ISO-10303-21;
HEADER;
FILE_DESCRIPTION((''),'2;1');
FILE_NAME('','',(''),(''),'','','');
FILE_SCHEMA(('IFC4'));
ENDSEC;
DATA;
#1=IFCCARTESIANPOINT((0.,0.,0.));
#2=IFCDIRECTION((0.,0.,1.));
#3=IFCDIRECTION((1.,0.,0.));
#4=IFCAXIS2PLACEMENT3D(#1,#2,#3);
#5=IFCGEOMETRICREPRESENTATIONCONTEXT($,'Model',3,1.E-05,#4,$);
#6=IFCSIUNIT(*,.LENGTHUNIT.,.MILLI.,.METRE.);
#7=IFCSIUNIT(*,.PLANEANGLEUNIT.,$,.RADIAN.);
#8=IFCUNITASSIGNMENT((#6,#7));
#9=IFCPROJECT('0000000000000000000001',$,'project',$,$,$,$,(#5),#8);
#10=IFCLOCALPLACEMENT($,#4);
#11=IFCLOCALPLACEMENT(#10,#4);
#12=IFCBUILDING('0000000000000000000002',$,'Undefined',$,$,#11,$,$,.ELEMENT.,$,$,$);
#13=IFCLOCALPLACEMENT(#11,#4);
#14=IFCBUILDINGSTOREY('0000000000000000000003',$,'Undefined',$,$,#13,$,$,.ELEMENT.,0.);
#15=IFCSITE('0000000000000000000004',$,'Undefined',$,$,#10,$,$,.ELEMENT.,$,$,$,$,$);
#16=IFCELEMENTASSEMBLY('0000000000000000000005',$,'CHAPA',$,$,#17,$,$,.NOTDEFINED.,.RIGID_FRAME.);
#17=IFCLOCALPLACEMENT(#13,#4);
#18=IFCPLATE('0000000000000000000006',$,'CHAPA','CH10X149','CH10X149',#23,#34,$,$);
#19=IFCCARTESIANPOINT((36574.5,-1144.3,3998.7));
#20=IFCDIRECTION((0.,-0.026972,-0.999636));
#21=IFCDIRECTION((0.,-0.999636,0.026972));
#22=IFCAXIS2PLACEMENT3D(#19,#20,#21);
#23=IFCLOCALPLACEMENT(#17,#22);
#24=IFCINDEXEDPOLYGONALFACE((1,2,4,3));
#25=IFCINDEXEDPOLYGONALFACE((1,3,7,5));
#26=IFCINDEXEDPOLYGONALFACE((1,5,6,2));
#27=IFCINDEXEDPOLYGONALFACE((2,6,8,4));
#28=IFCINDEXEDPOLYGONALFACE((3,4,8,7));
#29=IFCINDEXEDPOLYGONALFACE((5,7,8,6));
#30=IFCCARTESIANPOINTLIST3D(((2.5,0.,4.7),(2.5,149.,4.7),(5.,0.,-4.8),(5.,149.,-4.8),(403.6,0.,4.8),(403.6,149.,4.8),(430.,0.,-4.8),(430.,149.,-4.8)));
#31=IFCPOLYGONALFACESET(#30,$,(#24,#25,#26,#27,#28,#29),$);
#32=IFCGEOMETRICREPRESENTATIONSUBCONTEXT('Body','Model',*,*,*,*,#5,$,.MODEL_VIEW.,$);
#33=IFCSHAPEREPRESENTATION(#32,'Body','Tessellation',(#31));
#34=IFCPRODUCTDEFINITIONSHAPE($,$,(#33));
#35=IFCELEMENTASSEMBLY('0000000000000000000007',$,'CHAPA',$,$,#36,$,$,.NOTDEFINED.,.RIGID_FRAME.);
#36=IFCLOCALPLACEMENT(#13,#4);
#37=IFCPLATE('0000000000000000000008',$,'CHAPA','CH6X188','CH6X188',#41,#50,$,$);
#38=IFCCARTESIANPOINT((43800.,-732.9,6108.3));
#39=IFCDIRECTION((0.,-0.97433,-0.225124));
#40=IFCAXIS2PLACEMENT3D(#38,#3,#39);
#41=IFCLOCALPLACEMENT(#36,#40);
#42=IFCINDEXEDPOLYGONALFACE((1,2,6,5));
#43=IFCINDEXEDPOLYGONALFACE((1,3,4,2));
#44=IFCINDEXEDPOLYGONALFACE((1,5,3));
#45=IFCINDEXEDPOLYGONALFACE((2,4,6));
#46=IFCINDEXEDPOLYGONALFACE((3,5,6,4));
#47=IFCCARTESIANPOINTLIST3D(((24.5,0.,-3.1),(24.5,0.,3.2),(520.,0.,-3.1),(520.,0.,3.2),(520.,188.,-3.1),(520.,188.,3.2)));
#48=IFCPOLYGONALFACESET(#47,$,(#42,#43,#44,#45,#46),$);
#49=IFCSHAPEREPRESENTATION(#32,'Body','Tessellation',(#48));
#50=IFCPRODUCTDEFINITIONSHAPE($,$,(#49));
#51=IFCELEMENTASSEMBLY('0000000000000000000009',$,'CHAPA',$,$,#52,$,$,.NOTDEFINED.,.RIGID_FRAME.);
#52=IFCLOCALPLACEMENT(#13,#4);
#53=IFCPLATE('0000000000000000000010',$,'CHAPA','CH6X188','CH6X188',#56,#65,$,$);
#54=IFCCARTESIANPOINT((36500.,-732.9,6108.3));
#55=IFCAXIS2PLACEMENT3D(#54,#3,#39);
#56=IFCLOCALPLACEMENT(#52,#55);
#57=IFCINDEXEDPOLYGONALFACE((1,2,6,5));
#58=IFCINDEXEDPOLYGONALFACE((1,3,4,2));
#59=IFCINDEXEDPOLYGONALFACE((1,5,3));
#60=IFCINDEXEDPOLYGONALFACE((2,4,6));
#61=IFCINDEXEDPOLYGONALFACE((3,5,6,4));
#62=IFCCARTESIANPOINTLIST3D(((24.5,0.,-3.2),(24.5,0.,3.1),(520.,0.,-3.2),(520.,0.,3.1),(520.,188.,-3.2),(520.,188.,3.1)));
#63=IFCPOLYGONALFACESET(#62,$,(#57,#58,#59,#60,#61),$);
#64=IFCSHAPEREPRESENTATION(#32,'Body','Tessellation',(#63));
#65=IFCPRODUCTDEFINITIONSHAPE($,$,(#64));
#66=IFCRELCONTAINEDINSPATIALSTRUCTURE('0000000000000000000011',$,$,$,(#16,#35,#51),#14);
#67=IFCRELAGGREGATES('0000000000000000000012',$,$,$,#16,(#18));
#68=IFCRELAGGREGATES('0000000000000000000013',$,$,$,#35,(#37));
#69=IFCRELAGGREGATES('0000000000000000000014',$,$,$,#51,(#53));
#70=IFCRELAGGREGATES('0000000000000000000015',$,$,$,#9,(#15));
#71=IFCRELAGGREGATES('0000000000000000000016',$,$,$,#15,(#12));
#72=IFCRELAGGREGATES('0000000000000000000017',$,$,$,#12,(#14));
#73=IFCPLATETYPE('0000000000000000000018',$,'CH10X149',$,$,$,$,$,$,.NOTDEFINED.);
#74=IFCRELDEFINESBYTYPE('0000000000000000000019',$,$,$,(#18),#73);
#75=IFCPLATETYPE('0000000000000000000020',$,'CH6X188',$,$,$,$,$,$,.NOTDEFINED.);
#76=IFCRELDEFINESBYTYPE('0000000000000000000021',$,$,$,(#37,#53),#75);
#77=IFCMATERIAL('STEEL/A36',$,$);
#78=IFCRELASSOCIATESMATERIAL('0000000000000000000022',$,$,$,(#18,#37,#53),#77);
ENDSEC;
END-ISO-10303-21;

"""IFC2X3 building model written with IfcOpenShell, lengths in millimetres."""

from ifc_helpers import new_model, si_unit, frame, origin_with_axes, place, context, subcontext, project, spatial, polyline, outline, extrude, clip, halfspace, material, type_object, element, aggregate, save


model = new_model("IFC2X3")

# Units and contexts
model_context = context("Model", 3, precision=1e-05, world=origin_with_axes())
body_context = subcontext(model_context, "Body", "Model", "MODEL_VIEW")
ifc_project = project(units=[si_unit("LENGTHUNIT", "METRE", prefix="MILLI"), si_unit("PLANEANGLEUNIT", "RADIAN")], contexts=[model_context])

# Site, building, storey
site_placement = place(None, origin_with_axes())
site = spatial("IfcSite", under=ifc_project, at=site_placement, Name="Undefined", CompositionType="ELEMENT")
building_placement = place(site_placement, origin_with_axes())
building = spatial("IfcBuilding", under=site, at=building_placement, Name="Undefined", CompositionType="ELEMENT")
storey_placement = place(building_placement, origin_with_axes())
storey = spatial("IfcBuildingStorey", under=building, at=storey_placement, Name="Undefined", CompositionType="ELEMENT", Elevation=0.0)

# Shared definitions
ifc_material_1 = material(Name="STEEL/A36")

# Element assemblies, plates
plate_type_1 = type_object("IfcPlateType", Name="CH10X149", PredefinedType="NOTDEFINED")
assembly_1_placement = place(storey_placement, origin_with_axes())
assembly_1 = element("IfcElementAssembly", 1, at=assembly_1_placement, inside=storey, Name="CHAPA", AssemblyPlace="NOTDEFINED", PredefinedType="RIGID_FRAME")
plate_1_placement = place(assembly_1_placement, frame((36574.5, -1144.3, 3998.7), z_axis=(0.0, -0.026972, -0.999636), x_axis=(0.0, -0.999636, 0.026972)))
plate_1 = element("IfcPlate", 2, at=plate_1_placement, type_object=plate_type_1, material=ifc_material_1, Name="CHAPA", Description="CH10X149", ObjectType="CH10X149", context=body_context, shape_type="Clipping", body=[
    clip(clip(extrude(outline(polyline([(0.0, 0.0), (430.0, 0.0), (430.0, 149.0), (0.0, 149.0), (0.0, 0.0)])), frame((0.0, 0.0, -4.8), z_axis=(0.0, 0.0, 1.0), x_axis=(1.0, 0.0, 0.0)), (0.0, 0.0, 1.0), 9.5), halfspace(frame((403.6, -500.0, 4.7), z_axis=(0.33881, 0.0, 0.940855), x_axis=(0.0, 1.0, 0.0)), False)), halfspace(frame((5.0, -500.0, -4.8), z_axis=(-0.965989, 0.0, -0.258583), x_axis=(0.0, 1.0, 0.0)), False)),
])
aggregate(assembly_1, [plate_1])
assembly_2_placement = place(storey_placement, origin_with_axes())
assembly_2 = element("IfcElementAssembly", 3, at=assembly_2_placement, inside=storey, Name="CHAPA", AssemblyPlace="NOTDEFINED", PredefinedType="RIGID_FRAME")
plate_type_2 = type_object("IfcPlateType", Name="CH6X188", PredefinedType="NOTDEFINED")
plate_2_placement = place(assembly_2_placement, frame((43800.0, -732.9, 6108.3), z_axis=(1.0, 0.0, 0.0), x_axis=(0.0, -0.97433, -0.225124)))
plate_2 = element("IfcPlate", 4, at=plate_2_placement, type_object=plate_type_2, material=ifc_material_1, Name="CHAPA", Description="CH6X188", ObjectType="CH6X188", context=body_context, shape_type="Clipping", body=[
    clip(extrude(outline(polyline([(0.0, 0.0), (520.0, 0.0), (520.0, 191.6), (0.0, 0.0)])), frame((0.0, 0.0, -3.1), z_axis=(0.0, 0.0, 1.0), x_axis=(1.0, 0.0, 0.0)), (0.0, 0.0, 1.0), 6.3), halfspace(frame((1342.2, 500.0, 3.2), z_axis=(-0.354778, 0.934951, 0.0), x_axis=(-0.934951, -0.354778, 0.0)), False)),
])
aggregate(assembly_2, [plate_2])
assembly_3_placement = place(storey_placement, origin_with_axes())
assembly_3 = element("IfcElementAssembly", 5, at=assembly_3_placement, inside=storey, Name="CHAPA", AssemblyPlace="NOTDEFINED", PredefinedType="RIGID_FRAME")
plate_3_placement = place(assembly_3_placement, frame((36500.0, -732.9, 6108.3), z_axis=(1.0, 0.0, 0.0), x_axis=(0.0, -0.97433, -0.225124)))
plate_3 = element("IfcPlate", 6, at=plate_3_placement, type_object=plate_type_2, material=ifc_material_1, Name="CHAPA", Description="CH6X188", ObjectType="CH6X188", context=body_context, shape_type="Clipping", body=[
    clip(extrude(outline(polyline([(0.0, 0.0), (520.0, 0.0), (520.0, 191.6), (0.0, 0.0)])), frame((0.0, 0.0, -3.1), z_axis=(0.0, 0.0, 1.0), x_axis=(1.0, 0.0, 0.0)), (0.0, 0.0, 1.0), 6.3), halfspace(frame((1342.2, 500.0, 3.2), z_axis=(-0.354778, 0.934951, 0.0), x_axis=(-0.934951, -0.354778, 0.0)), False)),
])
aggregate(assembly_3, [plate_3])

save(model, "model.ifc")
